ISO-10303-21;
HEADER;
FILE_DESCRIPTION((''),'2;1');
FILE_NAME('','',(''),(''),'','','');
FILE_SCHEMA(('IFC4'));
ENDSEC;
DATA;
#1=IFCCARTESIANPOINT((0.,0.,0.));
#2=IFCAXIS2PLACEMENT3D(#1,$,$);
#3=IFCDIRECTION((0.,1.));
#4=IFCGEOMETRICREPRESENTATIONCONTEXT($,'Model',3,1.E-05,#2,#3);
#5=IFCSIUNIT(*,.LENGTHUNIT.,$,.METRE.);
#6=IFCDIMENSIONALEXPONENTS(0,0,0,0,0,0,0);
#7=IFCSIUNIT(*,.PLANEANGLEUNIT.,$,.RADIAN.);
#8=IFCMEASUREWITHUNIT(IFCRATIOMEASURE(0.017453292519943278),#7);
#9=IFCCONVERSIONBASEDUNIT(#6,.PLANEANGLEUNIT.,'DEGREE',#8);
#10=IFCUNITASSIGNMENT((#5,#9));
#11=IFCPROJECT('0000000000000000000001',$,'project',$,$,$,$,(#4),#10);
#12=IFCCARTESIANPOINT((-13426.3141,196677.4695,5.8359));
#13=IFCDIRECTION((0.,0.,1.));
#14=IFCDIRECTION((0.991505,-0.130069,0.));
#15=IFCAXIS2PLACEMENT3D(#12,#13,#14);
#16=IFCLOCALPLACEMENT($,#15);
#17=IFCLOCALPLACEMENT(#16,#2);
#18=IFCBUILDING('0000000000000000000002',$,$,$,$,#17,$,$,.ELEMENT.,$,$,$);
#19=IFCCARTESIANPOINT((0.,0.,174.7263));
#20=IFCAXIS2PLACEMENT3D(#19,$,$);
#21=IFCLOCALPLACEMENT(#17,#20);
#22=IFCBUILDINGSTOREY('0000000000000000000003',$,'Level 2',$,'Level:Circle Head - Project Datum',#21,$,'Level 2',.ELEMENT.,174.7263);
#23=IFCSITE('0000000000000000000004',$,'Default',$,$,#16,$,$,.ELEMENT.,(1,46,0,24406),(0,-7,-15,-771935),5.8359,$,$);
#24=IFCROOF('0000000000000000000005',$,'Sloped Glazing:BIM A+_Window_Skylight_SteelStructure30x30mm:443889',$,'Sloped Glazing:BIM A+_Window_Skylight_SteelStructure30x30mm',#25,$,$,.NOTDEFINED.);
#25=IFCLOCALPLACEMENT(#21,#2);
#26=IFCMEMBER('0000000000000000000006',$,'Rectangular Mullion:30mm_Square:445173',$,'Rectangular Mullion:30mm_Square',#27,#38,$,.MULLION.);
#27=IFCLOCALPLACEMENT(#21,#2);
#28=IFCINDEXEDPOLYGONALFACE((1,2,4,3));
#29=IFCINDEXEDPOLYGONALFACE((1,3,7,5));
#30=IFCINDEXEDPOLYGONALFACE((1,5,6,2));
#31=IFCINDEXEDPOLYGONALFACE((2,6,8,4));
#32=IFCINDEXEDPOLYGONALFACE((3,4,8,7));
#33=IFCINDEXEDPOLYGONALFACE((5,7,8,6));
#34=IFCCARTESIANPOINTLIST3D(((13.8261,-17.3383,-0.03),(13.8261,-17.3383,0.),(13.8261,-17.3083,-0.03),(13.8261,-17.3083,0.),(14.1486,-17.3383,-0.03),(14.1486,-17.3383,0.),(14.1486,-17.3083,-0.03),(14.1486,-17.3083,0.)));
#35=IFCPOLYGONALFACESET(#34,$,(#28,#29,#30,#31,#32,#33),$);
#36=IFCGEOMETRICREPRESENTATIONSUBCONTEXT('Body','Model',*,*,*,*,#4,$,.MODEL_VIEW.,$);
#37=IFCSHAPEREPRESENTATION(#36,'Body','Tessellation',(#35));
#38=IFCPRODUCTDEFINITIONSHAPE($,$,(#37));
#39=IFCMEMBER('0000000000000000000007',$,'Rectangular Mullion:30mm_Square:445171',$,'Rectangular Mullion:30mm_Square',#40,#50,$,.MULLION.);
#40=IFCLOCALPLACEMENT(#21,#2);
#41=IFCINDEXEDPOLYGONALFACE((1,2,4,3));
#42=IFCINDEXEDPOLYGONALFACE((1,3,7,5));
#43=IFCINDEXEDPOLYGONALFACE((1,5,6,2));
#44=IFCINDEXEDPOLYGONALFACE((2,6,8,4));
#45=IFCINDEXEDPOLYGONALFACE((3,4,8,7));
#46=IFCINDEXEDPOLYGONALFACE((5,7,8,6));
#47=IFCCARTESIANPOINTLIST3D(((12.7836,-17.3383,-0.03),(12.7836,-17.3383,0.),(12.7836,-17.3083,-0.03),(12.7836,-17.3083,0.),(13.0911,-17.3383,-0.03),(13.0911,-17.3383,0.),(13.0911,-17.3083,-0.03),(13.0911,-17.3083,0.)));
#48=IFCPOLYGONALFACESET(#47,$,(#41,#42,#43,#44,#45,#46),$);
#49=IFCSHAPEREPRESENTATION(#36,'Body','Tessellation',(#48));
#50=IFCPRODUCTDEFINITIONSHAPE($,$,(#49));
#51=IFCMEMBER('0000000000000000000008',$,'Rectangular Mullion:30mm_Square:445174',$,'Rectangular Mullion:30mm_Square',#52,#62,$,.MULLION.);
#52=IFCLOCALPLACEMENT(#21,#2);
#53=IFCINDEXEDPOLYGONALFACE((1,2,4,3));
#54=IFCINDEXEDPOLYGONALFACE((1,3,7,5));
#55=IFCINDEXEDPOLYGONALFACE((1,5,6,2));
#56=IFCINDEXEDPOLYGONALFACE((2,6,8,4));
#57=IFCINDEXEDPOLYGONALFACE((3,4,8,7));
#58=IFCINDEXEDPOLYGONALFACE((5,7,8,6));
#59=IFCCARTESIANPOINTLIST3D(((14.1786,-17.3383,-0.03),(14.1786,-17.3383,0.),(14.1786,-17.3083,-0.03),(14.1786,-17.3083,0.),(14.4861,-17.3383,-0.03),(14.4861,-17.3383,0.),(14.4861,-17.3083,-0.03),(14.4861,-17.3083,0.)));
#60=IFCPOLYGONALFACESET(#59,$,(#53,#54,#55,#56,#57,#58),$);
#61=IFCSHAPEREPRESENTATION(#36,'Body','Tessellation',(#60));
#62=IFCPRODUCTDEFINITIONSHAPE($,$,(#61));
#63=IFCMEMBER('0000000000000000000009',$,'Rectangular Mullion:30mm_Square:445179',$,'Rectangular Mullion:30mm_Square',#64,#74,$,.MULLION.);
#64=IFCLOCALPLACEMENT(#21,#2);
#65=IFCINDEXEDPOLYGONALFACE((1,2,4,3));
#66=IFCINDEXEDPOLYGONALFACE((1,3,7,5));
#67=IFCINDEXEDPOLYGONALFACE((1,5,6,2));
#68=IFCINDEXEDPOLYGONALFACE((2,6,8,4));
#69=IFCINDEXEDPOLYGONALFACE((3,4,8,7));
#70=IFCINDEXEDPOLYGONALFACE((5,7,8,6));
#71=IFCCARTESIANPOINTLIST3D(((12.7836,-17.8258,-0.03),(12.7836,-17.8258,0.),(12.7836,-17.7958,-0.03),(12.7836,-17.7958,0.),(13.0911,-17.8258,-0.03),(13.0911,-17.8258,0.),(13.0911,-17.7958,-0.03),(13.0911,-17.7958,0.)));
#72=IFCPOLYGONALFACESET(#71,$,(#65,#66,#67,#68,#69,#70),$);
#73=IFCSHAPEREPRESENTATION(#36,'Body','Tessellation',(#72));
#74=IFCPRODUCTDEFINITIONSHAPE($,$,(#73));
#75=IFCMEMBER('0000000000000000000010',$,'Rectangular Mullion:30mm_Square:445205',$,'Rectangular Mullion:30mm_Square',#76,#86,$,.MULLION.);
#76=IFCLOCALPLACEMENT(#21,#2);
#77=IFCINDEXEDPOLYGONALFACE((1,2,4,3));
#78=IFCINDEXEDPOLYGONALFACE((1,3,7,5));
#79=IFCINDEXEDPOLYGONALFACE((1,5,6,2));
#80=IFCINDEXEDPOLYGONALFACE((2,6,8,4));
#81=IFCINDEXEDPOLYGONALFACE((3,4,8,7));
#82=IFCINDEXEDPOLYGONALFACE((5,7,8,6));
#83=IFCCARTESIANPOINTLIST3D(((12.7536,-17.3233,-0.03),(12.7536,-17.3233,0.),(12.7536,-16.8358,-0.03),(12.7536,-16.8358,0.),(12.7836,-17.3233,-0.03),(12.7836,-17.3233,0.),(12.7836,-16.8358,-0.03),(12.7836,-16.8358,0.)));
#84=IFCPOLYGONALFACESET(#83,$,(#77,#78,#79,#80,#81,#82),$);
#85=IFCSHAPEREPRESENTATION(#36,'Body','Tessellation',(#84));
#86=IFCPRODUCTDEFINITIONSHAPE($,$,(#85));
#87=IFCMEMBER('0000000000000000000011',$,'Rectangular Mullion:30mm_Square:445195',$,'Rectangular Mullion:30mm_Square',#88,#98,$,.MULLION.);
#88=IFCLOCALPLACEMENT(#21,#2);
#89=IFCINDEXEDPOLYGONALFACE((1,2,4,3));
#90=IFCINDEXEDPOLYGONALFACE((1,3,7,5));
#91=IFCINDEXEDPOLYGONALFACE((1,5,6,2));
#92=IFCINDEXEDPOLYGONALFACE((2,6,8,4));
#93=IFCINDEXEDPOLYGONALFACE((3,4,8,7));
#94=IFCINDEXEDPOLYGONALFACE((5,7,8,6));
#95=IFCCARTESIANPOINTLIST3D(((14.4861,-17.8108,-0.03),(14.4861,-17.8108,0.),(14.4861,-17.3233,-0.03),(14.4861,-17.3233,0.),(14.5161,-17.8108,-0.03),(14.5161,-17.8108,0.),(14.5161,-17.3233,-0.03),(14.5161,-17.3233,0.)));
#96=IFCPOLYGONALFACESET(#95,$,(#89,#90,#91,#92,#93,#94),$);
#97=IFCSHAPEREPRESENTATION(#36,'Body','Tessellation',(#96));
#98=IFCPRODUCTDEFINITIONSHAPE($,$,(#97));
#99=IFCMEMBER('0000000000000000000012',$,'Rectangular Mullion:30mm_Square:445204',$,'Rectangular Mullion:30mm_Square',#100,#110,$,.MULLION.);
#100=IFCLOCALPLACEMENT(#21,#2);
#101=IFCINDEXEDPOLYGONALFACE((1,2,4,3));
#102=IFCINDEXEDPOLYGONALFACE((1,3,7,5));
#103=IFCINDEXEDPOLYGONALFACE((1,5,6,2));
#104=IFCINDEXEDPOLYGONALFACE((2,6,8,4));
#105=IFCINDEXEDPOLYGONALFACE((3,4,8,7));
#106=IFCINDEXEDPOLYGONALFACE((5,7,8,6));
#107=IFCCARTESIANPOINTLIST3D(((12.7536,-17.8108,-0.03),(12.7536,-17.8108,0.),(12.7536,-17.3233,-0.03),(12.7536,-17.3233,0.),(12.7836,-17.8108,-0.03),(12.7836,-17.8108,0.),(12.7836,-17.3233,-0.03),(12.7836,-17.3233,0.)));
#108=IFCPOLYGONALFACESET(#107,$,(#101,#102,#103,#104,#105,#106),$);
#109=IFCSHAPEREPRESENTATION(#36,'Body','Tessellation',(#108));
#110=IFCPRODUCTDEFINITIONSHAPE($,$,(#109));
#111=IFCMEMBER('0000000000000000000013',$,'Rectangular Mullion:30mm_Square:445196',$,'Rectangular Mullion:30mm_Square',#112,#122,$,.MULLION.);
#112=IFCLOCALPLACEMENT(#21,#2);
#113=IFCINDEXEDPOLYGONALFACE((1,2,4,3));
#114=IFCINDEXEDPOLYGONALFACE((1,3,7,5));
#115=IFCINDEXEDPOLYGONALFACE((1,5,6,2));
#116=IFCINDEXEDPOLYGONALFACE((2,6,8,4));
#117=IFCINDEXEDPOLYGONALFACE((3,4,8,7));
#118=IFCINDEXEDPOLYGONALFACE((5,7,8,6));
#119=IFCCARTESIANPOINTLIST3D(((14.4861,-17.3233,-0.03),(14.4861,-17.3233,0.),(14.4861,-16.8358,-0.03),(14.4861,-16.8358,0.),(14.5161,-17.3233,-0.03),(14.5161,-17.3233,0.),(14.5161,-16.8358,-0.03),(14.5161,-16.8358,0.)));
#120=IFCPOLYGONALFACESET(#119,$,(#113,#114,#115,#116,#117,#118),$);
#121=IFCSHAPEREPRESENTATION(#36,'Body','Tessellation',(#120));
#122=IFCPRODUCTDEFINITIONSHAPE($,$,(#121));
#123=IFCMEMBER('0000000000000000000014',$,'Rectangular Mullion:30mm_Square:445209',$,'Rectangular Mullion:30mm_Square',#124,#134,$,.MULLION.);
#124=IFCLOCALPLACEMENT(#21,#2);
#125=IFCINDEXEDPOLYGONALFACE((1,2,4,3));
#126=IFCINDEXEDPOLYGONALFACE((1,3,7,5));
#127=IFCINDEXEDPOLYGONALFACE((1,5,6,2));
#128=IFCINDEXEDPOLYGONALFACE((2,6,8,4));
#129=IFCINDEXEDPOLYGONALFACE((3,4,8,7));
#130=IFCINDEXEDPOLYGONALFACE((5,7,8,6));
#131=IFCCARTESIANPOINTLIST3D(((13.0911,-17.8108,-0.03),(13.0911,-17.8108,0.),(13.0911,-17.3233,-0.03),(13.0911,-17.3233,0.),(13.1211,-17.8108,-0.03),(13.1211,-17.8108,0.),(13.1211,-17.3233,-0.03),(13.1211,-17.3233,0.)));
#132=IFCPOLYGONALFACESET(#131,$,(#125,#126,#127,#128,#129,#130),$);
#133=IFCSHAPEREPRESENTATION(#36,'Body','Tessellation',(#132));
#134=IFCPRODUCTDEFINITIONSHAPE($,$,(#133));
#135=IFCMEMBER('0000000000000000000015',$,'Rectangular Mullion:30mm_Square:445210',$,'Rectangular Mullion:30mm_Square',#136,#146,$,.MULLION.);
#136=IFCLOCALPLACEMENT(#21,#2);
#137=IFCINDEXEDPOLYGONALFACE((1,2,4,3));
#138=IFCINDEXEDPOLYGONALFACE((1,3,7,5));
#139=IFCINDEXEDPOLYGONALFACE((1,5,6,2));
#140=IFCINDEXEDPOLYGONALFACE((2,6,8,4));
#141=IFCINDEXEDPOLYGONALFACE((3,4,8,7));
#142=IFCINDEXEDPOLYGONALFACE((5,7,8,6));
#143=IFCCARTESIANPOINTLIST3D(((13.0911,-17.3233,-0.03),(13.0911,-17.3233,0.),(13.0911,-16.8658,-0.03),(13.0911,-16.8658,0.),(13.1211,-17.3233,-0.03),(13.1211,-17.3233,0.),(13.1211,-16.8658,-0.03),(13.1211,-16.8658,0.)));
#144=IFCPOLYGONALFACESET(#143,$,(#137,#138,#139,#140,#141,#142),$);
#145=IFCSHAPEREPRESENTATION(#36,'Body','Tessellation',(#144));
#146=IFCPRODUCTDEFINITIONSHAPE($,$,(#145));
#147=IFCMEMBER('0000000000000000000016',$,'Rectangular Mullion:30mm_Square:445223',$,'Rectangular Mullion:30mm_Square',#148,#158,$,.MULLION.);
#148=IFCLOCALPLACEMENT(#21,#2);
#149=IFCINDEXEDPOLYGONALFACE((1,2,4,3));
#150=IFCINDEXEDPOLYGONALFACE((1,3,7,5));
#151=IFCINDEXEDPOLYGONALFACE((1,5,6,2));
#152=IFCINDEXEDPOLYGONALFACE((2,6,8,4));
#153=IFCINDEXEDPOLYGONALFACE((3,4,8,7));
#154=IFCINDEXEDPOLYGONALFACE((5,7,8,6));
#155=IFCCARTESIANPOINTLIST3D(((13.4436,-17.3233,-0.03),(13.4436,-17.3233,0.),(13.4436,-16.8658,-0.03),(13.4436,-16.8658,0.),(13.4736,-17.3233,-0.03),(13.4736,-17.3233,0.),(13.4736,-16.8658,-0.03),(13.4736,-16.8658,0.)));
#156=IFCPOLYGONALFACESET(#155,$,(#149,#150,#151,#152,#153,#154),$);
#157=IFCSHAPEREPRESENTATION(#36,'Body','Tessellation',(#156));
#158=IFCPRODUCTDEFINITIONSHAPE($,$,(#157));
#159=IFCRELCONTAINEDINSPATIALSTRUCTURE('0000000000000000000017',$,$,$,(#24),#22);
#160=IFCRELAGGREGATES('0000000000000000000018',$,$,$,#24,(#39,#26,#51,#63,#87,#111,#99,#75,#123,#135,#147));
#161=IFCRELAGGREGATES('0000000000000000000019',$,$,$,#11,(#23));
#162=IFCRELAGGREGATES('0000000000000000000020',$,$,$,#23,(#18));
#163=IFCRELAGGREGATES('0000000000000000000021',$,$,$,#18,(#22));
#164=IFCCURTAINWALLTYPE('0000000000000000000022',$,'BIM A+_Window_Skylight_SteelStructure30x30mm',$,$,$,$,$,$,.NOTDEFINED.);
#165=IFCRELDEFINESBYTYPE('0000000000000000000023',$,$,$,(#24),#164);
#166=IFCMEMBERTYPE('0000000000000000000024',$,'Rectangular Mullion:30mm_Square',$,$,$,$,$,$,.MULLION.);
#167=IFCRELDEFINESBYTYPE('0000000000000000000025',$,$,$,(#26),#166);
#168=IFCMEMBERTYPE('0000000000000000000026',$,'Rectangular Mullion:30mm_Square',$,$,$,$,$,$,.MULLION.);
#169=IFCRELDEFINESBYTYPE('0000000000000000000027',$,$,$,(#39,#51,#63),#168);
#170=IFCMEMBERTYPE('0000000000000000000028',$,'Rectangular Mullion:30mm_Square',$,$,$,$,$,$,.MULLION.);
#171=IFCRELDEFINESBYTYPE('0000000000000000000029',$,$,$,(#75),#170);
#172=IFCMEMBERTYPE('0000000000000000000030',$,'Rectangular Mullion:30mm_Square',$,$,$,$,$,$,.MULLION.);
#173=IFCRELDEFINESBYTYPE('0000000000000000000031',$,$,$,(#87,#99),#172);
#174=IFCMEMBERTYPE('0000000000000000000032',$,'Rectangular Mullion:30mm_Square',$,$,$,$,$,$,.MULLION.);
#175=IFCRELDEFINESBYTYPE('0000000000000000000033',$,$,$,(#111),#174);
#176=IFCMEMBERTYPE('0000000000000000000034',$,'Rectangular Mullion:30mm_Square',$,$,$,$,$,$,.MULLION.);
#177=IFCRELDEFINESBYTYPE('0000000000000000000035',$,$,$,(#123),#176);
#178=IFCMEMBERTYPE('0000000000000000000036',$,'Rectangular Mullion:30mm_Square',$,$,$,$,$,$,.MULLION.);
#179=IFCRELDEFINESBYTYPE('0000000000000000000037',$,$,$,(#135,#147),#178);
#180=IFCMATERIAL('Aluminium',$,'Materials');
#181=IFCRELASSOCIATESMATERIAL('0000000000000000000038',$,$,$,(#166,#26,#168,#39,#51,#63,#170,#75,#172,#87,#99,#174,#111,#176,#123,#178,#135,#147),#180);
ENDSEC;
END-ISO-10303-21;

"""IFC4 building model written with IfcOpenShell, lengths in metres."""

from ifc_helpers import new_model, entity, si_unit, converted_unit, direction, frame, origin, place, context, subcontext, project, spatial, indexed_curve, outline, extrude, source, transform, mapped, material, type_object, type_shapes, element, aggregate, save


model = new_model("IFC4")

# Units and contexts
model_context = context("Model", 3, precision=1e-05, world=origin(), true_north=direction((0.0, 1.0)))
body_context = subcontext(model_context, "Body", "Model", "MODEL_VIEW")
ifc_project = project(units=[si_unit("LENGTHUNIT", "METRE"), converted_unit("PLANEANGLEUNIT", "DEGREE", entity("IfcRatioMeasure", 0.017453292519943278), si_unit("PLANEANGLEUNIT", "RADIAN"), dimensions=[0, 0, 0, 0, 0, 0, 0])], contexts=[model_context])

# Site, building, storey
site_placement = place(None, frame((-13426.3141, 196677.4695, 5.8359), z_axis=(0.0, 0.0, 1.0), x_axis=(0.991505, -0.130069, 0.0)))
site = spatial("IfcSite", under=ifc_project, at=site_placement, Name="Default", CompositionType="ELEMENT", RefLatitude=(1, 46, 0, 24406), RefLongitude=(0, -7, -15, -771935), RefElevation=5.8359)
building_placement = place(site_placement, origin())
building = spatial("IfcBuilding", under=site, at=building_placement, CompositionType="ELEMENT")
storey_placement = place(building_placement, frame((0.0, 0.0, 174.7263)))
storey = spatial("IfcBuildingStorey", under=building, at=storey_placement, Name="Level 2", ObjectType="Level:Circle Head - Project Datum", LongName="Level 2", CompositionType="ELEMENT", Elevation=174.7263)

# Roof, members
curtain_wall_type = type_object("IfcCurtainWallType", Name="BIM A+_Window_Skylight_SteelStructure30x30mm", PredefinedType="NOTDEFINED")
ifc_material_1 = material(Name="Aluminium", Category="Materials")
roof_1_placement = place(storey_placement, frame((0.0, 0.0, -174.7263)))
roof_1 = element("IfcRoof", 1, at=roof_1_placement, inside=storey, type_object=curtain_wall_type, Name="Sloped Glazing:BIM A+_Window_Skylight_SteelStructure30x30mm:443889", ObjectType="Sloped Glazing:BIM A+_Window_Skylight_SteelStructure30x30mm", PredefinedType="NOTDEFINED")
member_type_1 = type_object("IfcMemberType", Name="Rectangular Mullion:30mm_Square", PredefinedType="MULLION", material=ifc_material_1)
shared_shape_1 = source(origin(), body_context, "Body", "SweptSolid", [
    extrude(outline(indexed_curve([(-0.015, -0.015), (0.015, -0.015), (0.015, 0.015), (-0.015, 0.015), (-0.015, -0.015)], self_intersect=False)), frame((0.0, 0.0, -0.3225), z_axis=(0.0, 0.0, 1.0), x_axis=(0.0, -1.0, 0.0)), (0.0, 0.0, 1.0), 0.3225),
])
type_shapes(member_type_1, [shared_shape_1])
member_1_placement = place(roof_1_placement, frame((14.1486, -17.3233, 174.7113), z_axis=(1.0, 0.0, 0.0), x_axis=(0.0, -1.0, 0.0)))
member_1 = element("IfcMember", 2, at=member_1_placement, type_object=member_type_1, material=ifc_material_1, Name="Rectangular Mullion:30mm_Square:445173", ObjectType="Rectangular Mullion:30mm_Square", PredefinedType="MULLION", context=body_context, shape_type="MappedRepresentation", body=[
    mapped(shared_shape_1, transform((0.0, 0.0, 0.0), scale=1.0)),
])
member_type_2 = type_object("IfcMemberType", Name="Rectangular Mullion:30mm_Square", PredefinedType="MULLION", material=ifc_material_1)
shared_shape_2 = source(origin(), body_context, "Body", "SweptSolid", [
    extrude(outline(indexed_curve([(-0.015, -0.015), (0.015, -0.015), (0.015, 0.015), (-0.015, 0.015), (-0.015, -0.015)], self_intersect=False)), frame((0.0, 0.0, -0.3075), z_axis=(0.0, 0.0, 1.0), x_axis=(0.0, -1.0, 0.0)), (0.0, 0.0, 1.0), 0.3075),
])
type_shapes(member_type_2, [shared_shape_2])
member_2_placement = place(roof_1_placement, frame((13.0911, -17.3233, 174.7113), z_axis=(1.0, 0.0, 0.0), x_axis=(0.0, -1.0, 0.0)))
member_2 = element("IfcMember", 3, at=member_2_placement, type_object=member_type_2, material=ifc_material_1, Name="Rectangular Mullion:30mm_Square:445171", ObjectType="Rectangular Mullion:30mm_Square", PredefinedType="MULLION", context=body_context, shape_type="MappedRepresentation", body=[
    mapped(shared_shape_2, transform((0.0, 0.0, 0.0), scale=1.0)),
])
member_3_placement = place(roof_1_placement, frame((14.4861, -17.3233, 174.7113), z_axis=(1.0, 0.0, 0.0), x_axis=(0.0, -1.0, 0.0)))
member_3 = element("IfcMember", 4, at=member_3_placement, type_object=member_type_2, material=ifc_material_1, Name="Rectangular Mullion:30mm_Square:445174", ObjectType="Rectangular Mullion:30mm_Square", PredefinedType="MULLION", context=body_context, shape_type="MappedRepresentation", body=[
    mapped(shared_shape_2, transform((0.0, 0.0, 0.0), scale=1.0)),
])
member_4_placement = place(roof_1_placement, frame((13.0911, -17.8108, 174.7113), z_axis=(1.0, 0.0, 0.0), x_axis=(0.0, -1.0, 0.0)))
member_4 = element("IfcMember", 5, at=member_4_placement, type_object=member_type_2, material=ifc_material_1, Name="Rectangular Mullion:30mm_Square:445179", ObjectType="Rectangular Mullion:30mm_Square", PredefinedType="MULLION", context=body_context, shape_type="MappedRepresentation", body=[
    mapped(shared_shape_2, transform((0.0, 0.0, 0.0), scale=1.0)),
])
member_type_3 = type_object("IfcMemberType", Name="Rectangular Mullion:30mm_Square", PredefinedType="MULLION", material=ifc_material_1)
shared_shape_3 = source(origin(), body_context, "Body", "SweptSolid", [
    extrude(outline(indexed_curve([(-0.015, -0.015), (0.015, -0.015), (0.015, 0.015), (-0.015, 0.015), (-0.015, -0.015)], self_intersect=False)), frame((-0.015, 0.0, -0.4875), z_axis=(0.0, 0.0, 1.0), x_axis=(0.0, -1.0, 0.0)), (0.0, 0.0, 1.0), 0.4875),
])
type_shapes(member_type_3, [shared_shape_3])
member_5_placement = place(roof_1_placement, frame((12.7536, -17.3233, 174.7113), z_axis=(0.0, -1.0, 0.0), x_axis=(-1.0, 0.0, 0.0)))
member_5 = element("IfcMember", 6, at=member_5_placement, type_object=member_type_3, material=ifc_material_1, Name="Rectangular Mullion:30mm_Square:445205", ObjectType="Rectangular Mullion:30mm_Square", PredefinedType="MULLION", context=body_context, shape_type="MappedRepresentation", body=[
    mapped(shared_shape_3, transform((0.0, 0.0, 0.0), scale=1.0)),
])
member_type_4 = type_object("IfcMemberType", Name="Rectangular Mullion:30mm_Square", PredefinedType="MULLION", material=ifc_material_1)
shared_shape_4 = source(origin(), body_context, "Body", "SweptSolid", [
    extrude(outline(indexed_curve([(-0.015, -0.015), (0.015, -0.015), (0.015, 0.015), (-0.015, 0.015), (-0.015, -0.015)], self_intersect=False)), frame((-0.015, 0.0, -0.4875), z_axis=(0.0, 0.0, 1.0), x_axis=(0.0, -1.0, 0.0)), (0.0, 0.0, 1.0), 0.4875),
])
type_shapes(member_type_4, [shared_shape_4])
member_6_placement = place(roof_1_placement, frame((14.5161, -17.3233, 174.7113), z_axis=(0.0, 1.0, 0.0), x_axis=(1.0, 0.0, 0.0)))
member_6 = element("IfcMember", 7, at=member_6_placement, type_object=member_type_4, material=ifc_material_1, Name="Rectangular Mullion:30mm_Square:445195", ObjectType="Rectangular Mullion:30mm_Square", PredefinedType="MULLION", context=body_context, shape_type="MappedRepresentation", body=[
    mapped(shared_shape_4, transform((0.0, 0.0, 0.0), scale=1.0)),
])
member_7_placement = place(roof_1_placement, frame((12.7536, -17.8108, 174.7113), z_axis=(0.0, -1.0, 0.0), x_axis=(-1.0, 0.0, 0.0)))
member_7 = element("IfcMember", 8, at=member_7_placement, type_object=member_type_4, material=ifc_material_1, Name="Rectangular Mullion:30mm_Square:445204", ObjectType="Rectangular Mullion:30mm_Square", PredefinedType="MULLION", context=body_context, shape_type="MappedRepresentation", body=[
    mapped(shared_shape_4, transform((0.0, 0.0, 0.0), scale=1.0)),
])
member_type_5 = type_object("IfcMemberType", Name="Rectangular Mullion:30mm_Square", PredefinedType="MULLION", material=ifc_material_1)
shared_shape_5 = source(origin(), body_context, "Body", "SweptSolid", [
    extrude(outline(indexed_curve([(-0.015, -0.015), (0.015, -0.015), (0.015, 0.015), (-0.015, 0.015), (-0.015, -0.015)], self_intersect=False)), frame((-0.015, 0.0, -0.4875), z_axis=(0.0, 0.0, 1.0), x_axis=(0.0, -1.0, 0.0)), (0.0, 0.0, 1.0), 0.4875),
])
type_shapes(member_type_5, [shared_shape_5])
member_8_placement = place(roof_1_placement, frame((14.5161, -16.8358, 174.7113), z_axis=(0.0, 1.0, 0.0), x_axis=(1.0, 0.0, 0.0)))
member_8 = element("IfcMember", 9, at=member_8_placement, type_object=member_type_5, material=ifc_material_1, Name="Rectangular Mullion:30mm_Square:445196", ObjectType="Rectangular Mullion:30mm_Square", PredefinedType="MULLION", context=body_context, shape_type="MappedRepresentation", body=[
    mapped(shared_shape_5, transform((0.0, 0.0, 0.0), scale=1.0)),
])
member_type_6 = type_object("IfcMemberType", Name="Rectangular Mullion:30mm_Square", PredefinedType="MULLION", material=ifc_material_1)
shared_shape_6 = source(origin(), body_context, "Body", "SweptSolid", [
    extrude(outline(indexed_curve([(-0.015, -0.015), (0.015, -0.015), (0.015, 0.015), (-0.015, 0.015), (-0.015, -0.015)], self_intersect=False)), frame((0.0, 0.0, -0.4875), z_axis=(0.0, 0.0, 1.0), x_axis=(0.0, -1.0, 0.0)), (0.0, 0.0, 1.0), 0.4875),
])
type_shapes(member_type_6, [shared_shape_6])
member_9_placement = place(roof_1_placement, frame((13.1061, -17.8108, 174.7113), z_axis=(0.0, -1.0, 0.0), x_axis=(-1.0, 0.0, 0.0)))
member_9 = element("IfcMember", 10, at=member_9_placement, type_object=member_type_6, material=ifc_material_1, Name="Rectangular Mullion:30mm_Square:445209", ObjectType="Rectangular Mullion:30mm_Square", PredefinedType="MULLION", context=body_context, shape_type="MappedRepresentation", body=[
    mapped(shared_shape_6, transform((0.0, 0.0, 0.0), scale=1.0)),
])
member_type_7 = type_object("IfcMemberType", Name="Rectangular Mullion:30mm_Square", PredefinedType="MULLION", material=ifc_material_1)
shared_shape_7 = source(origin(), body_context, "Body", "SweptSolid", [
    extrude(outline(indexed_curve([(-0.015, -0.015), (0.015, -0.015), (0.015, 0.015), (-0.015, 0.015), (-0.015, -0.015)], self_intersect=False)), frame((0.0, 0.0, -0.4575), z_axis=(0.0, 0.0, 1.0), x_axis=(0.0, -1.0, 0.0)), (0.0, 0.0, 1.0), 0.4575),
])
type_shapes(member_type_7, [shared_shape_7])
member_10_placement = place(roof_1_placement, frame((13.1061, -17.3233, 174.7113), z_axis=(0.0, -1.0, 0.0), x_axis=(-1.0, 0.0, 0.0)))
member_10 = element("IfcMember", 11, at=member_10_placement, type_object=member_type_7, material=ifc_material_1, Name="Rectangular Mullion:30mm_Square:445210", ObjectType="Rectangular Mullion:30mm_Square", PredefinedType="MULLION", context=body_context, shape_type="MappedRepresentation", body=[
    mapped(shared_shape_7, transform((0.0, 0.0, 0.0), scale=1.0)),
])
member_11_placement = place(roof_1_placement, frame((13.4586, -17.3233, 174.7113), z_axis=(0.0, -1.0, 0.0), x_axis=(-1.0, 0.0, 0.0)))
member_11 = element("IfcMember", 12, at=member_11_placement, type_object=member_type_7, material=ifc_material_1, Name="Rectangular Mullion:30mm_Square:445223", ObjectType="Rectangular Mullion:30mm_Square", PredefinedType="MULLION", context=body_context, shape_type="MappedRepresentation", body=[
    mapped(shared_shape_7, transform((0.0, 0.0, 0.0), scale=1.0)),
])

aggregate(roof_1, [member_2, member_1, member_3, member_4, member_6, member_8, member_7, member_5, member_9, member_10, member_11])

save(model, "model.ifc")
